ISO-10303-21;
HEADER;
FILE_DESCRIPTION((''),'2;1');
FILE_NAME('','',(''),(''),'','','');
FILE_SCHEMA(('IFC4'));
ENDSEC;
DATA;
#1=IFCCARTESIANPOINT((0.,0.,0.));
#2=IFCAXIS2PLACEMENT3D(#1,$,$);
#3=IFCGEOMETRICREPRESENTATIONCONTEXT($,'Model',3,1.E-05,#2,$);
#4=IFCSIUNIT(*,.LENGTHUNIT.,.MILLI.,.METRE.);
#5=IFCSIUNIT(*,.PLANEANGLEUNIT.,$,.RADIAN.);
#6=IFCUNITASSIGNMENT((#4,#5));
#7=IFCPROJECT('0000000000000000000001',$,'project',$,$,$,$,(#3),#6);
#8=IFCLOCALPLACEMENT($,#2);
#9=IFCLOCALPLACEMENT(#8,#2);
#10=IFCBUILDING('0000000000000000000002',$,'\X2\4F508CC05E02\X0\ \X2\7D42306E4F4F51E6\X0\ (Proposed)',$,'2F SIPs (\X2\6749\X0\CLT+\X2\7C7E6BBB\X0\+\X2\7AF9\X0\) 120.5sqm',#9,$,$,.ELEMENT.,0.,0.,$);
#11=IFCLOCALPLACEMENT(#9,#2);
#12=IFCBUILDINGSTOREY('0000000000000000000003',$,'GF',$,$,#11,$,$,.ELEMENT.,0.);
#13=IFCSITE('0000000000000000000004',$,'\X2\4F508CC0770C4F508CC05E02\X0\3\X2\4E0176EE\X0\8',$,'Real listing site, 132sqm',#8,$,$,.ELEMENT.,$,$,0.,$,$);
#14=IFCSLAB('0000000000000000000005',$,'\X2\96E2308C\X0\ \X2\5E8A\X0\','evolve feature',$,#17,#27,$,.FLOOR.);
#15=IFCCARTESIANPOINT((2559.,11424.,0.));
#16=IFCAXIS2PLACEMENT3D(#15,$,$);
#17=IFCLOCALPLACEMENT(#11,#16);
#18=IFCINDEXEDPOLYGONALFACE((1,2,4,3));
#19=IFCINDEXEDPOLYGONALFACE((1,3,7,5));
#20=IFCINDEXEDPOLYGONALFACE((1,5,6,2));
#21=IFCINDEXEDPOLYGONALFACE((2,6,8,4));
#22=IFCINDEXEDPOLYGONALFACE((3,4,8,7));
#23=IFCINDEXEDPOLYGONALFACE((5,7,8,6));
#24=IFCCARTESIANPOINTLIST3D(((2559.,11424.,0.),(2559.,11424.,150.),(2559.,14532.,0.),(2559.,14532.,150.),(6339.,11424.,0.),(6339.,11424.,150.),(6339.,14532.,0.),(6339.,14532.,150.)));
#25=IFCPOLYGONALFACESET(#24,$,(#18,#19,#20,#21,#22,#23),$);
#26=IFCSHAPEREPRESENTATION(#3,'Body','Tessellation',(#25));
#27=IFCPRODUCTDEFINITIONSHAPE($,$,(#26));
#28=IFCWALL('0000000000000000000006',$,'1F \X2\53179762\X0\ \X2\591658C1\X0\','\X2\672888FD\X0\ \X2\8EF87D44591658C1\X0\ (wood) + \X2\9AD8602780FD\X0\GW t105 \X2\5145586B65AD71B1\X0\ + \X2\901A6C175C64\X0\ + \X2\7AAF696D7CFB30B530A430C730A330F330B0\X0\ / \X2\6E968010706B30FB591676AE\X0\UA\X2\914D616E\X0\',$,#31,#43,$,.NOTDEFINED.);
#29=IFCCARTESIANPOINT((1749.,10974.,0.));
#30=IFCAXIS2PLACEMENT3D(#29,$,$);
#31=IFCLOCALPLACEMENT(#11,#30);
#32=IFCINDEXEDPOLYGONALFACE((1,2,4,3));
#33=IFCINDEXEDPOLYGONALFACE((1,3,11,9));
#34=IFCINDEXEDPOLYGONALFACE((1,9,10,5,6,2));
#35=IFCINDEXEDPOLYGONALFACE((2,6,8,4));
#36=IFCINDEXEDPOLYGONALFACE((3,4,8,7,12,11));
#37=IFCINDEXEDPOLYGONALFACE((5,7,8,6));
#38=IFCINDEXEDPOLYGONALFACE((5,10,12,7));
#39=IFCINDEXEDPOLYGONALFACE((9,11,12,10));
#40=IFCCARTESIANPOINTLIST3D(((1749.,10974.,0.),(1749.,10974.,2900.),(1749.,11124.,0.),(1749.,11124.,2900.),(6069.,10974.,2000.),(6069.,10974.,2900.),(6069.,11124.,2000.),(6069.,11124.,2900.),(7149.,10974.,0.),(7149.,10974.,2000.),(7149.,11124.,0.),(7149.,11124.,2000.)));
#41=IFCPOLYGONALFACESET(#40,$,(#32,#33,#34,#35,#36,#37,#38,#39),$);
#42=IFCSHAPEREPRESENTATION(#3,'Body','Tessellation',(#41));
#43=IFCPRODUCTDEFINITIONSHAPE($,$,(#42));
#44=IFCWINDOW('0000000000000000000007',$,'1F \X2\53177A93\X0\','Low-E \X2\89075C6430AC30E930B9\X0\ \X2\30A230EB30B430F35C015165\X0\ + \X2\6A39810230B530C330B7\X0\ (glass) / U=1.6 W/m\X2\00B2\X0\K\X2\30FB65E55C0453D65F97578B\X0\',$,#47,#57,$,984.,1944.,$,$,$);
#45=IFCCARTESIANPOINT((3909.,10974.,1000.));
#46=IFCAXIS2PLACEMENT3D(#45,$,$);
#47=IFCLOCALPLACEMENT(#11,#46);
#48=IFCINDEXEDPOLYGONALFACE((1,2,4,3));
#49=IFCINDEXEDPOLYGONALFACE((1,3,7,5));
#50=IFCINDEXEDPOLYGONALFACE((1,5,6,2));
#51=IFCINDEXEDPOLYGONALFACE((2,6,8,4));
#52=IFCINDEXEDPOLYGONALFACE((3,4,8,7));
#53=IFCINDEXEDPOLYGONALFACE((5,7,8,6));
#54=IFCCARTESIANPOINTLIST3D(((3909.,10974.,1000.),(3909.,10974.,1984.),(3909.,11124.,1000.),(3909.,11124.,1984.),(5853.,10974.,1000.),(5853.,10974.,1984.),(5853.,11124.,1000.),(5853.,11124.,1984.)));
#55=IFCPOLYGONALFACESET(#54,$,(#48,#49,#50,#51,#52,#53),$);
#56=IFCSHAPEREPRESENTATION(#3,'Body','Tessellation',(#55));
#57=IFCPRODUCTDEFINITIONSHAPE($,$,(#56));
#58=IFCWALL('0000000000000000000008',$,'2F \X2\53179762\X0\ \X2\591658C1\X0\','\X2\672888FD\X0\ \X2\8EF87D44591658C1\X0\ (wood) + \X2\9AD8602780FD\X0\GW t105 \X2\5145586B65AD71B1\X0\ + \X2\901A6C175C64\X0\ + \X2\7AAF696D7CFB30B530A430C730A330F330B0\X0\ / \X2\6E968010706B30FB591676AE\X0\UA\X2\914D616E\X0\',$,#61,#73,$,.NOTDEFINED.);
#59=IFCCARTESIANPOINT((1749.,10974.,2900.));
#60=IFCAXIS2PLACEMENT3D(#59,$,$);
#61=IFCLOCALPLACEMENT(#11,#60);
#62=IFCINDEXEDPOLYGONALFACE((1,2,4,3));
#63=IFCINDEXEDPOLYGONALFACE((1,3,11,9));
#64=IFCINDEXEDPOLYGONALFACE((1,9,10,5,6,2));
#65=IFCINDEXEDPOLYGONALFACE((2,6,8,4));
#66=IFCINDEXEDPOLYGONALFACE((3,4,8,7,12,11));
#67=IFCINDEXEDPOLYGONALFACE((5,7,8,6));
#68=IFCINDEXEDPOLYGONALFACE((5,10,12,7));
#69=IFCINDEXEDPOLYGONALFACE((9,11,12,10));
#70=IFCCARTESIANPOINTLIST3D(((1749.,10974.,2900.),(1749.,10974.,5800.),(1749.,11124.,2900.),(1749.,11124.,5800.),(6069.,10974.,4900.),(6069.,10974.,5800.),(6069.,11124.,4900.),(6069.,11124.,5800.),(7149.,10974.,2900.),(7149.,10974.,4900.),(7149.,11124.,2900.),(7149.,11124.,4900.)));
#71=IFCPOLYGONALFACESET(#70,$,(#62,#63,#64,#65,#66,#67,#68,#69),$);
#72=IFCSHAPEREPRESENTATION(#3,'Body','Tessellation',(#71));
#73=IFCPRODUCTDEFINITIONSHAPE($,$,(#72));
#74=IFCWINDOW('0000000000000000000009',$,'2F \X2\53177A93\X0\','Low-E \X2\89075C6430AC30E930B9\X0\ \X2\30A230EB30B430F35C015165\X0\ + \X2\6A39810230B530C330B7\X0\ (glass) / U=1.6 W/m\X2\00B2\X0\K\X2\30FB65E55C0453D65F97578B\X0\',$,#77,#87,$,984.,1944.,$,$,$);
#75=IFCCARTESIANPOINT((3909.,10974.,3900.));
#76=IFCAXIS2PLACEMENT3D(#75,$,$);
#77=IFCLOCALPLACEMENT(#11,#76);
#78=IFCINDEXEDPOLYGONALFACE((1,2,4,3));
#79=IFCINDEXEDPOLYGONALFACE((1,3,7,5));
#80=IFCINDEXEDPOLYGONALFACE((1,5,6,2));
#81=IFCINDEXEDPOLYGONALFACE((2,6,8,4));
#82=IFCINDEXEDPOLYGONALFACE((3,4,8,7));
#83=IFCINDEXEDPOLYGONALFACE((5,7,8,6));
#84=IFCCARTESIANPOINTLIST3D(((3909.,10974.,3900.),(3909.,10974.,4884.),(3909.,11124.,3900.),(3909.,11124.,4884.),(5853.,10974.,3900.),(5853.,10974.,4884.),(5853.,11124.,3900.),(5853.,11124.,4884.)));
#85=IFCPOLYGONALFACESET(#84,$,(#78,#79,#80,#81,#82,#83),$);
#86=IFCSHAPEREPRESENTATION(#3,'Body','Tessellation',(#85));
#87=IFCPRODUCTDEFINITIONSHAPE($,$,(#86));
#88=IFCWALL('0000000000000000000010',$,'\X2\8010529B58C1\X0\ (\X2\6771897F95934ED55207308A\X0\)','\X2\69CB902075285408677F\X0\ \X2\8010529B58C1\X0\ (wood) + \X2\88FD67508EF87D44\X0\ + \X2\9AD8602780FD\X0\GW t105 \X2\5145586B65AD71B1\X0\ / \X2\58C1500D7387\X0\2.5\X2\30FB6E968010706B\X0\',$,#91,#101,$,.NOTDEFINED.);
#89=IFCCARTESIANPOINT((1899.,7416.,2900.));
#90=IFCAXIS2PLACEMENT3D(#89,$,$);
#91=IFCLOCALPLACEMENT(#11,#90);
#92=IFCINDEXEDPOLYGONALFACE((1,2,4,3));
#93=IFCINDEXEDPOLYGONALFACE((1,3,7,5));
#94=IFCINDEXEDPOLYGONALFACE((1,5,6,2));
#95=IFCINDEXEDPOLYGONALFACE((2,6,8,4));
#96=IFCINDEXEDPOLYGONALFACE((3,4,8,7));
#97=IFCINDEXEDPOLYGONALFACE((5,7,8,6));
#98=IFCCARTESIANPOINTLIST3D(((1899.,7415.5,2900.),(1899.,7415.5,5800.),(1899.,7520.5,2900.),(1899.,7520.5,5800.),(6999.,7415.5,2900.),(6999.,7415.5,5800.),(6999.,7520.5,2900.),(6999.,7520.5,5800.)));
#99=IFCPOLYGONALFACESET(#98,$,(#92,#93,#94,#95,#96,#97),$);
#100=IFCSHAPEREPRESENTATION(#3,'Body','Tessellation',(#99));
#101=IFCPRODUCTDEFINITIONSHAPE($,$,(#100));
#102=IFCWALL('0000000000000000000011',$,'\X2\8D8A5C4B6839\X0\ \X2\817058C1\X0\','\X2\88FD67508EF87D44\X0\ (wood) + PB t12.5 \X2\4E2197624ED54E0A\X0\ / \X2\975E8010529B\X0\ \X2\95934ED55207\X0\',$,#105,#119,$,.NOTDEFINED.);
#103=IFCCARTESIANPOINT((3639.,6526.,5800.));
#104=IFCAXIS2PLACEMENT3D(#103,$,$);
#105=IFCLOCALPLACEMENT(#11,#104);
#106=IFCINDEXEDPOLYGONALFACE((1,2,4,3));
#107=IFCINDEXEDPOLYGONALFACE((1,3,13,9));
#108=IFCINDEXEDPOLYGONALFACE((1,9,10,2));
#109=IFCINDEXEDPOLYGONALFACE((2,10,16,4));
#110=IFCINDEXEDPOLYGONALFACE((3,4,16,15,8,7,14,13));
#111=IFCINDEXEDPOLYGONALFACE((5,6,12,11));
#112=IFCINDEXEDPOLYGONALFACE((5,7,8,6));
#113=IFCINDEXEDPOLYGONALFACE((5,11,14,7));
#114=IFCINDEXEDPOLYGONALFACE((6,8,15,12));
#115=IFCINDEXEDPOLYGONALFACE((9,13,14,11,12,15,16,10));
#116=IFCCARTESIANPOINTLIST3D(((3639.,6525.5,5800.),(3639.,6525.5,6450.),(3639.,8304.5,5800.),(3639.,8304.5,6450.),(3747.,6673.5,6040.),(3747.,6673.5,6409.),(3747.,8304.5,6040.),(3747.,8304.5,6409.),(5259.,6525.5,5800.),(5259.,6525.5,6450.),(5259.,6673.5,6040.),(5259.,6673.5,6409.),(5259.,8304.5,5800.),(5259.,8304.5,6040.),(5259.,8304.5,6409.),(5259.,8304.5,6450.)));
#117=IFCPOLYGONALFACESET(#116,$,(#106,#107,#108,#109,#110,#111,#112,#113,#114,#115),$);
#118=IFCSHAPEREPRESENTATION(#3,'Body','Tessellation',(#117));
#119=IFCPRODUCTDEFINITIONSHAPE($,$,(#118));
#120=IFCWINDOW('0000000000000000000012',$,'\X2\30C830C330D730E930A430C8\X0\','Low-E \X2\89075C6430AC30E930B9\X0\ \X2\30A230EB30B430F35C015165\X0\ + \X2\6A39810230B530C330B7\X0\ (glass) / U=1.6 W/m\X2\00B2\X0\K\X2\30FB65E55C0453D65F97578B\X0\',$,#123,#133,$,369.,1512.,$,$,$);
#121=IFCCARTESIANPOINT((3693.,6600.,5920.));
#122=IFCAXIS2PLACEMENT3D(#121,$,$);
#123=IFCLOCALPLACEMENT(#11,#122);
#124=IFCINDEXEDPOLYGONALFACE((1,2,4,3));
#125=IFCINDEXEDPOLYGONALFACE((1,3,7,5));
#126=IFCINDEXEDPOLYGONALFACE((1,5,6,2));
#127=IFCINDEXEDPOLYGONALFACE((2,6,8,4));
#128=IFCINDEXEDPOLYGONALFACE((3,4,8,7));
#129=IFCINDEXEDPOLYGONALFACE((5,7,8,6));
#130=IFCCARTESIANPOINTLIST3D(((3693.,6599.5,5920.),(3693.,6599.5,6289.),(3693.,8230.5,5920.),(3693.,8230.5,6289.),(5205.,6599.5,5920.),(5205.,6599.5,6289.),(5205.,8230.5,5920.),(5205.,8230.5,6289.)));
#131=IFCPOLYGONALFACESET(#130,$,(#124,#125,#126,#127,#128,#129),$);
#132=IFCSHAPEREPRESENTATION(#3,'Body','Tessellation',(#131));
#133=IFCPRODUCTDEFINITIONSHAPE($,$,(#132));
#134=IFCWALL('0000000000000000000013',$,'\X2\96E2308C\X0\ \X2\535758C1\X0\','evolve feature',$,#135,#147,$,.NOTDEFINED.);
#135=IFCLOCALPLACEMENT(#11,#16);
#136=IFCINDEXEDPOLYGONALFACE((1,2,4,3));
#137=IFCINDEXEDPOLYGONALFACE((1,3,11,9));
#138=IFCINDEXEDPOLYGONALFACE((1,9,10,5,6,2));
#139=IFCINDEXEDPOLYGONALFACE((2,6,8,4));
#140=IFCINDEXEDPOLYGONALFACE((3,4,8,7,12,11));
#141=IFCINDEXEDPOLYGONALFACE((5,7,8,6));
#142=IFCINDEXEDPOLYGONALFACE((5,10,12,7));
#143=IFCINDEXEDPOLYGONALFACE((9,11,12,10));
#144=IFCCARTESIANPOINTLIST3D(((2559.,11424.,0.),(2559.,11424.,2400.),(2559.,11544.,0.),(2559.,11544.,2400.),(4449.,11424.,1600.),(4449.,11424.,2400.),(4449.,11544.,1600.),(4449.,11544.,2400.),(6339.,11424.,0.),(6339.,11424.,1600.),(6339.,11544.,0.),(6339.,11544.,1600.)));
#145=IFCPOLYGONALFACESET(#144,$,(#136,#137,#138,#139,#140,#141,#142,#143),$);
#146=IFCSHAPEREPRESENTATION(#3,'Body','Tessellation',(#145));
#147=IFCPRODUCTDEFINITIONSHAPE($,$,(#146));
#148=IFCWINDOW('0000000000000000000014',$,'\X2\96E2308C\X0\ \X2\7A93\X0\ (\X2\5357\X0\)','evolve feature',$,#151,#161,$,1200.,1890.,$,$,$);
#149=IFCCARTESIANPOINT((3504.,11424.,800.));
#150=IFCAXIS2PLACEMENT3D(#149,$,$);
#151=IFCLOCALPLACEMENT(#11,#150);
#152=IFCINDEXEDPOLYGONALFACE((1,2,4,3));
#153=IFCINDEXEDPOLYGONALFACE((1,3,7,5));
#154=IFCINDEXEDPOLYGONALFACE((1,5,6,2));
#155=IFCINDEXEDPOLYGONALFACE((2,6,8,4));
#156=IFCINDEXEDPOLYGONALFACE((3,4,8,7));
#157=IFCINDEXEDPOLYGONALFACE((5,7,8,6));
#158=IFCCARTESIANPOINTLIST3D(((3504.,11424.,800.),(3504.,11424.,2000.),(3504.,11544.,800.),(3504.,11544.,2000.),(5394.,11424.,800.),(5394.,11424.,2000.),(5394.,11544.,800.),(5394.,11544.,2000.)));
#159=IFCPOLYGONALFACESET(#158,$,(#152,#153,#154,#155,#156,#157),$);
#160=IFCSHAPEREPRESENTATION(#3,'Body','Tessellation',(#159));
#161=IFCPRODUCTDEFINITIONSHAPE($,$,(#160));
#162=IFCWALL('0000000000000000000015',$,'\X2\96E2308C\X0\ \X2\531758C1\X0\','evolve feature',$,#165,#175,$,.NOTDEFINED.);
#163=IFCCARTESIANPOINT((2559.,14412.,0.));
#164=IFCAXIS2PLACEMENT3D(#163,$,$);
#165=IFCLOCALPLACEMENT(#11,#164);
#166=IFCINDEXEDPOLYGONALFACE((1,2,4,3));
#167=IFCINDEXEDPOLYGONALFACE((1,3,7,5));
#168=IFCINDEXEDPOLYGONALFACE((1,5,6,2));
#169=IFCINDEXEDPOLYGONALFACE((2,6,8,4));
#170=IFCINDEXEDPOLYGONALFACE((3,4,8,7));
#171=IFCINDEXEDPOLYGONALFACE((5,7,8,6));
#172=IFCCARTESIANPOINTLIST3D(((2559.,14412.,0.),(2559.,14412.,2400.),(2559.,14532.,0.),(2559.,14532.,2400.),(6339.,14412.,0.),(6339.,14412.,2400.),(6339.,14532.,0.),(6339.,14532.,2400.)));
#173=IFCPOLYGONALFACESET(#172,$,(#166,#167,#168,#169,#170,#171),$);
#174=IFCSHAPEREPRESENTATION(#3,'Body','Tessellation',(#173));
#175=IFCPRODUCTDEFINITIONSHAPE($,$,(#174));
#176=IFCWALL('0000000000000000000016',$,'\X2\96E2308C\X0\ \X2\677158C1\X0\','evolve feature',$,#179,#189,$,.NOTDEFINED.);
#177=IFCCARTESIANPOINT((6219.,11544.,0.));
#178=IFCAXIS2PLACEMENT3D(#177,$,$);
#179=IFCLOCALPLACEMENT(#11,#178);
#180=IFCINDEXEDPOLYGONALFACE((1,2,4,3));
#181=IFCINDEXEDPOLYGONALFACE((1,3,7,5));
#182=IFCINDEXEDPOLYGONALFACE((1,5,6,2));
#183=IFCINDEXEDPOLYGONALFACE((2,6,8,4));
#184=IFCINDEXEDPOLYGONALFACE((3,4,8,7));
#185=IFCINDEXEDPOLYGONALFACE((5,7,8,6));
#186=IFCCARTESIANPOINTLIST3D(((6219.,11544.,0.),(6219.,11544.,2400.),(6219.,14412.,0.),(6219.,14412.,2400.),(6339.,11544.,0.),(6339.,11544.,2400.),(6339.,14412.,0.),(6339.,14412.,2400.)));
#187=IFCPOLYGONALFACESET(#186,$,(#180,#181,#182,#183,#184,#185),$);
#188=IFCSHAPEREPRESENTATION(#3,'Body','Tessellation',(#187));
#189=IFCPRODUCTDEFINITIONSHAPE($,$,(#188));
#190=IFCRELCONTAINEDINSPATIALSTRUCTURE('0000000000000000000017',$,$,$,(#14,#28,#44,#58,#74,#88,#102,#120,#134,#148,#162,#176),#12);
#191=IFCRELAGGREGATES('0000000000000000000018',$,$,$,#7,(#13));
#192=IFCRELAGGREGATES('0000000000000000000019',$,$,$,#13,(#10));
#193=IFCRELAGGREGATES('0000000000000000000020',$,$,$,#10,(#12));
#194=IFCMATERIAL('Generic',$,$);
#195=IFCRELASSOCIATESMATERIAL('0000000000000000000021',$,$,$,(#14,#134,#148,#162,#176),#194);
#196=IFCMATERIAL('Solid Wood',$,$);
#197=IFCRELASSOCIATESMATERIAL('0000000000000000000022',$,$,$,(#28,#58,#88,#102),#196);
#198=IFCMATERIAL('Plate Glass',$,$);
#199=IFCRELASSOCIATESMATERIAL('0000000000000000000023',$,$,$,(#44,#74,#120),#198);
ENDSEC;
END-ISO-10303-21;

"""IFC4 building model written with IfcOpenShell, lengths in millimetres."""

from ifc_helpers import new_model, si_unit, frame, frame_2d, origin, place, context, project, spatial, rectangle, extrude, material, element, fill, save


model = new_model("IFC4")

# Units and contexts
model_context = context("Model", 3, precision=1e-05, world=origin())
ifc_project = project(units=[si_unit("LENGTHUNIT", "METRE", prefix="MILLI"), si_unit("PLANEANGLEUNIT", "RADIAN")], contexts=[model_context])

# Site, building, storey
site_placement = place(None, origin())
site = spatial("IfcSite", under=ifc_project, at=site_placement, Name="佐賀県佐賀市3丁目8", ObjectType="Real listing site, 132sqm", CompositionType="ELEMENT", RefElevation=0.0)
building_placement = place(site_placement, origin())
building = spatial("IfcBuilding", under=site, at=building_placement, Name="佐賀市 終の住処 (Proposed)", ObjectType="2F SIPs (杉CLT+籾殻+竹) 120.5sqm", CompositionType="ELEMENT", ElevationOfRefHeight=0.0, ElevationOfTerrain=0.0)
storey_placement = place(building_placement, origin())
storey = spatial("IfcBuildingStorey", under=building, at=storey_placement, Name="GF", CompositionType="ELEMENT", Elevation=0.0)

# Slab
ifc_material_1 = material(Name="Generic")
slab_placement = place(storey_placement, frame((2559.0, 11424.0, 0.0)))
element("IfcSlab", 1, at=slab_placement, inside=storey, material=ifc_material_1, Name="離れ 床", Description="evolve feature", PredefinedType="FLOOR", context=model_context, shape_type="SweptSolid", body=[
    extrude(rectangle(XDim=3780.0, YDim=3108.0, at=frame_2d((1890.0, 1554.0))), frame((2559.0, 11424.0, 0.0)), (0.0, 0.0, 1.0), 150.0),
])

# Wall, opening, window
ifc_material_2 = material(Name="Solid Wood")
wall_1_placement = place(storey_placement, frame((1749.0, 10974.0, 0.0)))
wall_1 = element("IfcWall", 2, at=wall_1_placement, inside=storey, material=ifc_material_2, Name="1F 北面 外壁", Description="木製 軸組外壁 (wood) + 高性能GW t105 充填断熱 + 通気層 + 窯業系サイディング / 準耐火・外皮UA配慮", PredefinedType="NOTDEFINED", context=model_context, shape_type="SweptSolid", body=[
    extrude(rectangle(XDim=5400.0, YDim=150.0, at=frame_2d((2700.0, 75.0))), frame((1749.0, 10974.0, 0.0)), (0.0, 0.0, 1.0), 2900.0),
])
opening_1_placement = place(storey_placement, frame((3909.0, 10974.0, 1000.0)))
opening_1 = element("IfcOpeningElement", 3, at=opening_1_placement, cuts=wall_1, PredefinedType="NOTDEFINED", context=model_context, shape_type="SweptSolid", body=[
    extrude(rectangle(XDim=1944.0, YDim=150.0, at=frame_2d((972.0, 75.0))), frame((3909.0, 10974.0, 1000.0)), (0.0, 0.0, 1.0), 984.0),
])
ifc_material_3 = material(Name="Plate Glass")
window_1_placement = place(storey_placement, frame((3909.0, 10974.0, 1000.0)))
window_1 = element("IfcWindow", 4, at=window_1_placement, inside=storey, material=ifc_material_3, Name="1F 北窓", Description="Low-E 複層ガラス アルゴン封入 + 樹脂サッシ (glass) / U=1.6 W/m²K・日射取得型", OverallHeight=984.0, OverallWidth=1944.0, context=model_context, shape_type="SweptSolid", body=[
    extrude(rectangle(XDim=1944.0, YDim=150.0, at=frame_2d((972.0, 75.0))), frame((3909.0, 10974.0, 1000.0)), (0.0, 0.0, 1.0), 984.0),
])
fill(opening_1, window_1)

# Wall, opening, window
wall_2_placement = place(storey_placement, frame((1749.0, 10974.0, 2900.0)))
wall_2 = element("IfcWall", 5, at=wall_2_placement, inside=storey, material=ifc_material_2, Name="2F 北面 外壁", Description="木製 軸組外壁 (wood) + 高性能GW t105 充填断熱 + 通気層 + 窯業系サイディング / 準耐火・外皮UA配慮", PredefinedType="NOTDEFINED", context=model_context, shape_type="SweptSolid", body=[
    extrude(rectangle(XDim=5400.0, YDim=150.0, at=frame_2d((2700.0, 75.0))), frame((1749.0, 10974.0, 2900.0)), (0.0, 0.0, 1.0), 2900.0),
])
opening_2_placement = place(storey_placement, frame((3909.0, 10974.0, 3900.0)))
opening_2 = element("IfcOpeningElement", 6, at=opening_2_placement, cuts=wall_2, PredefinedType="NOTDEFINED", context=model_context, shape_type="SweptSolid", body=[
    extrude(rectangle(XDim=1944.0, YDim=150.0, at=frame_2d((972.0, 75.0))), frame((3909.0, 10974.0, 3900.0)), (0.0, 0.0, 1.0), 984.0),
])
window_2_placement = place(storey_placement, frame((3909.0, 10974.0, 3900.0)))
window_2 = element("IfcWindow", 7, at=window_2_placement, inside=storey, material=ifc_material_3, Name="2F 北窓", Description="Low-E 複層ガラス アルゴン封入 + 樹脂サッシ (glass) / U=1.6 W/m²K・日射取得型", OverallHeight=984.0, OverallWidth=1944.0, context=model_context, shape_type="SweptSolid", body=[
    extrude(rectangle(XDim=1944.0, YDim=150.0, at=frame_2d((972.0, 75.0))), frame((3909.0, 10974.0, 3900.0)), (0.0, 0.0, 1.0), 984.0),
])
fill(opening_2, window_2)

# Wall
wall_3_placement = place(storey_placement, frame((1899.0, 7416.0, 2900.0)))
element("IfcWall", 8, at=wall_3_placement, inside=storey, material=ifc_material_2, Name="耐力壁 (東西間仕切り)", Description="構造用合板 耐力壁 (wood) + 製材軸組 + 高性能GW t105 充填断熱 / 壁倍率2.5・準耐火", PredefinedType="NOTDEFINED", context=model_context, shape_type="SweptSolid", body=[
    extrude(rectangle(XDim=5100.0, YDim=105.0, at=frame_2d((2550.0, 52.0))), frame((1899.0, 7416.0, 2900.0)), (0.0, 0.0, 1.0), 2900.0),
])

# Walls, openings, windows
wall_4_placement = place(storey_placement, frame((3639.0, 6526.0, 5800.0)))
wall_4 = element("IfcWall", 9, at=wall_4_placement, inside=storey, material=ifc_material_2, Name="越屋根 腰壁", Description="製材軸組 (wood) + PB t12.5 両面仕上 / 非耐力 間仕切", PredefinedType="NOTDEFINED", context=model_context, shape_type="SweptSolid", body=[
    extrude(rectangle(XDim=1620.0, YDim=1779.0, at=frame_2d((810.0, 889.0))), frame((3639.0, 6526.0, 5800.0)), (0.0, 0.0, 1.0), 650.0),
])
opening_3_placement = place(storey_placement, frame((3693.0, 6600.0, 5920.0)))
opening_3 = element("IfcOpeningElement", 10, at=opening_3_placement, cuts=wall_4, PredefinedType="NOTDEFINED", context=model_context, shape_type="SweptSolid", body=[
    extrude(rectangle(XDim=1512.0, YDim=1631.0, at=frame_2d((756.0, 815.0))), frame((3693.0, 6600.0, 5920.0)), (0.0, 0.0, 1.0), 369.0),
])
window_3_placement = place(storey_placement, frame((3693.0, 6600.0, 5920.0)))
window_3 = element("IfcWindow", 11, at=window_3_placement, inside=storey, material=ifc_material_3, Name="トップライト", Description="Low-E 複層ガラス アルゴン封入 + 樹脂サッシ (glass) / U=1.6 W/m²K・日射取得型", OverallHeight=369.0, OverallWidth=1512.0, context=model_context, shape_type="SweptSolid", body=[
    extrude(rectangle(XDim=1512.0, YDim=1631.0, at=frame_2d((756.0, 815.0))), frame((3693.0, 6600.0, 5920.0)), (0.0, 0.0, 1.0), 369.0),
])
fill(opening_3, window_3)
wall_5_placement = place(storey_placement, frame((2559.0, 11424.0, 0.0)))
wall_5 = element("IfcWall", 12, at=wall_5_placement, inside=storey, material=ifc_material_1, Name="離れ 南壁", Description="evolve feature", PredefinedType="NOTDEFINED", context=model_context, shape_type="SweptSolid", body=[
    extrude(rectangle(XDim=3780.0, YDim=120.0, at=frame_2d((1890.0, 60.0))), frame((2559.0, 11424.0, 0.0)), (0.0, 0.0, 1.0), 2400.0),
])
opening_4_placement = place(storey_placement, frame((3504.0, 11424.0, 800.0)))
opening_4 = element("IfcOpeningElement", 13, at=opening_4_placement, cuts=wall_5, PredefinedType="NOTDEFINED", context=model_context, shape_type="SweptSolid", body=[
    extrude(rectangle(XDim=1890.0, YDim=120.0, at=frame_2d((945.0, 60.0))), frame((3504.0, 11424.0, 800.0)), (0.0, 0.0, 1.0), 1200.0),
])
window_4_placement = place(storey_placement, frame((3504.0, 11424.0, 800.0)))
window_4 = element("IfcWindow", 14, at=window_4_placement, inside=storey, material=ifc_material_1, Name="離れ 窓 (南)", Description="evolve feature", OverallHeight=1200.0, OverallWidth=1890.0, context=model_context, shape_type="SweptSolid", body=[
    extrude(rectangle(XDim=1890.0, YDim=120.0, at=frame_2d((945.0, 60.0))), frame((3504.0, 11424.0, 800.0)), (0.0, 0.0, 1.0), 1200.0),
])
fill(opening_4, window_4)

# Walls
wall_6_placement = place(storey_placement, frame((2559.0, 14412.0, 0.0)))
element("IfcWall", 15, at=wall_6_placement, inside=storey, material=ifc_material_1, Name="離れ 北壁", Description="evolve feature", PredefinedType="NOTDEFINED", context=model_context, shape_type="SweptSolid", body=[
    extrude(rectangle(XDim=3780.0, YDim=120.0, at=frame_2d((1890.0, 60.0))), frame((2559.0, 14412.0, 0.0)), (0.0, 0.0, 1.0), 2400.0),
])
wall_7_placement = place(storey_placement, frame((6219.0, 11544.0, 0.0)))
element("IfcWall", 16, at=wall_7_placement, inside=storey, material=ifc_material_1, Name="離れ 東壁", Description="evolve feature", PredefinedType="NOTDEFINED", context=model_context, shape_type="SweptSolid", body=[
    extrude(rectangle(XDim=120.0, YDim=2868.0, at=frame_2d((60.0, 1434.0))), frame((6219.0, 11544.0, 0.0)), (0.0, 0.0, 1.0), 2400.0),
])

save(model, "model.ifc")
